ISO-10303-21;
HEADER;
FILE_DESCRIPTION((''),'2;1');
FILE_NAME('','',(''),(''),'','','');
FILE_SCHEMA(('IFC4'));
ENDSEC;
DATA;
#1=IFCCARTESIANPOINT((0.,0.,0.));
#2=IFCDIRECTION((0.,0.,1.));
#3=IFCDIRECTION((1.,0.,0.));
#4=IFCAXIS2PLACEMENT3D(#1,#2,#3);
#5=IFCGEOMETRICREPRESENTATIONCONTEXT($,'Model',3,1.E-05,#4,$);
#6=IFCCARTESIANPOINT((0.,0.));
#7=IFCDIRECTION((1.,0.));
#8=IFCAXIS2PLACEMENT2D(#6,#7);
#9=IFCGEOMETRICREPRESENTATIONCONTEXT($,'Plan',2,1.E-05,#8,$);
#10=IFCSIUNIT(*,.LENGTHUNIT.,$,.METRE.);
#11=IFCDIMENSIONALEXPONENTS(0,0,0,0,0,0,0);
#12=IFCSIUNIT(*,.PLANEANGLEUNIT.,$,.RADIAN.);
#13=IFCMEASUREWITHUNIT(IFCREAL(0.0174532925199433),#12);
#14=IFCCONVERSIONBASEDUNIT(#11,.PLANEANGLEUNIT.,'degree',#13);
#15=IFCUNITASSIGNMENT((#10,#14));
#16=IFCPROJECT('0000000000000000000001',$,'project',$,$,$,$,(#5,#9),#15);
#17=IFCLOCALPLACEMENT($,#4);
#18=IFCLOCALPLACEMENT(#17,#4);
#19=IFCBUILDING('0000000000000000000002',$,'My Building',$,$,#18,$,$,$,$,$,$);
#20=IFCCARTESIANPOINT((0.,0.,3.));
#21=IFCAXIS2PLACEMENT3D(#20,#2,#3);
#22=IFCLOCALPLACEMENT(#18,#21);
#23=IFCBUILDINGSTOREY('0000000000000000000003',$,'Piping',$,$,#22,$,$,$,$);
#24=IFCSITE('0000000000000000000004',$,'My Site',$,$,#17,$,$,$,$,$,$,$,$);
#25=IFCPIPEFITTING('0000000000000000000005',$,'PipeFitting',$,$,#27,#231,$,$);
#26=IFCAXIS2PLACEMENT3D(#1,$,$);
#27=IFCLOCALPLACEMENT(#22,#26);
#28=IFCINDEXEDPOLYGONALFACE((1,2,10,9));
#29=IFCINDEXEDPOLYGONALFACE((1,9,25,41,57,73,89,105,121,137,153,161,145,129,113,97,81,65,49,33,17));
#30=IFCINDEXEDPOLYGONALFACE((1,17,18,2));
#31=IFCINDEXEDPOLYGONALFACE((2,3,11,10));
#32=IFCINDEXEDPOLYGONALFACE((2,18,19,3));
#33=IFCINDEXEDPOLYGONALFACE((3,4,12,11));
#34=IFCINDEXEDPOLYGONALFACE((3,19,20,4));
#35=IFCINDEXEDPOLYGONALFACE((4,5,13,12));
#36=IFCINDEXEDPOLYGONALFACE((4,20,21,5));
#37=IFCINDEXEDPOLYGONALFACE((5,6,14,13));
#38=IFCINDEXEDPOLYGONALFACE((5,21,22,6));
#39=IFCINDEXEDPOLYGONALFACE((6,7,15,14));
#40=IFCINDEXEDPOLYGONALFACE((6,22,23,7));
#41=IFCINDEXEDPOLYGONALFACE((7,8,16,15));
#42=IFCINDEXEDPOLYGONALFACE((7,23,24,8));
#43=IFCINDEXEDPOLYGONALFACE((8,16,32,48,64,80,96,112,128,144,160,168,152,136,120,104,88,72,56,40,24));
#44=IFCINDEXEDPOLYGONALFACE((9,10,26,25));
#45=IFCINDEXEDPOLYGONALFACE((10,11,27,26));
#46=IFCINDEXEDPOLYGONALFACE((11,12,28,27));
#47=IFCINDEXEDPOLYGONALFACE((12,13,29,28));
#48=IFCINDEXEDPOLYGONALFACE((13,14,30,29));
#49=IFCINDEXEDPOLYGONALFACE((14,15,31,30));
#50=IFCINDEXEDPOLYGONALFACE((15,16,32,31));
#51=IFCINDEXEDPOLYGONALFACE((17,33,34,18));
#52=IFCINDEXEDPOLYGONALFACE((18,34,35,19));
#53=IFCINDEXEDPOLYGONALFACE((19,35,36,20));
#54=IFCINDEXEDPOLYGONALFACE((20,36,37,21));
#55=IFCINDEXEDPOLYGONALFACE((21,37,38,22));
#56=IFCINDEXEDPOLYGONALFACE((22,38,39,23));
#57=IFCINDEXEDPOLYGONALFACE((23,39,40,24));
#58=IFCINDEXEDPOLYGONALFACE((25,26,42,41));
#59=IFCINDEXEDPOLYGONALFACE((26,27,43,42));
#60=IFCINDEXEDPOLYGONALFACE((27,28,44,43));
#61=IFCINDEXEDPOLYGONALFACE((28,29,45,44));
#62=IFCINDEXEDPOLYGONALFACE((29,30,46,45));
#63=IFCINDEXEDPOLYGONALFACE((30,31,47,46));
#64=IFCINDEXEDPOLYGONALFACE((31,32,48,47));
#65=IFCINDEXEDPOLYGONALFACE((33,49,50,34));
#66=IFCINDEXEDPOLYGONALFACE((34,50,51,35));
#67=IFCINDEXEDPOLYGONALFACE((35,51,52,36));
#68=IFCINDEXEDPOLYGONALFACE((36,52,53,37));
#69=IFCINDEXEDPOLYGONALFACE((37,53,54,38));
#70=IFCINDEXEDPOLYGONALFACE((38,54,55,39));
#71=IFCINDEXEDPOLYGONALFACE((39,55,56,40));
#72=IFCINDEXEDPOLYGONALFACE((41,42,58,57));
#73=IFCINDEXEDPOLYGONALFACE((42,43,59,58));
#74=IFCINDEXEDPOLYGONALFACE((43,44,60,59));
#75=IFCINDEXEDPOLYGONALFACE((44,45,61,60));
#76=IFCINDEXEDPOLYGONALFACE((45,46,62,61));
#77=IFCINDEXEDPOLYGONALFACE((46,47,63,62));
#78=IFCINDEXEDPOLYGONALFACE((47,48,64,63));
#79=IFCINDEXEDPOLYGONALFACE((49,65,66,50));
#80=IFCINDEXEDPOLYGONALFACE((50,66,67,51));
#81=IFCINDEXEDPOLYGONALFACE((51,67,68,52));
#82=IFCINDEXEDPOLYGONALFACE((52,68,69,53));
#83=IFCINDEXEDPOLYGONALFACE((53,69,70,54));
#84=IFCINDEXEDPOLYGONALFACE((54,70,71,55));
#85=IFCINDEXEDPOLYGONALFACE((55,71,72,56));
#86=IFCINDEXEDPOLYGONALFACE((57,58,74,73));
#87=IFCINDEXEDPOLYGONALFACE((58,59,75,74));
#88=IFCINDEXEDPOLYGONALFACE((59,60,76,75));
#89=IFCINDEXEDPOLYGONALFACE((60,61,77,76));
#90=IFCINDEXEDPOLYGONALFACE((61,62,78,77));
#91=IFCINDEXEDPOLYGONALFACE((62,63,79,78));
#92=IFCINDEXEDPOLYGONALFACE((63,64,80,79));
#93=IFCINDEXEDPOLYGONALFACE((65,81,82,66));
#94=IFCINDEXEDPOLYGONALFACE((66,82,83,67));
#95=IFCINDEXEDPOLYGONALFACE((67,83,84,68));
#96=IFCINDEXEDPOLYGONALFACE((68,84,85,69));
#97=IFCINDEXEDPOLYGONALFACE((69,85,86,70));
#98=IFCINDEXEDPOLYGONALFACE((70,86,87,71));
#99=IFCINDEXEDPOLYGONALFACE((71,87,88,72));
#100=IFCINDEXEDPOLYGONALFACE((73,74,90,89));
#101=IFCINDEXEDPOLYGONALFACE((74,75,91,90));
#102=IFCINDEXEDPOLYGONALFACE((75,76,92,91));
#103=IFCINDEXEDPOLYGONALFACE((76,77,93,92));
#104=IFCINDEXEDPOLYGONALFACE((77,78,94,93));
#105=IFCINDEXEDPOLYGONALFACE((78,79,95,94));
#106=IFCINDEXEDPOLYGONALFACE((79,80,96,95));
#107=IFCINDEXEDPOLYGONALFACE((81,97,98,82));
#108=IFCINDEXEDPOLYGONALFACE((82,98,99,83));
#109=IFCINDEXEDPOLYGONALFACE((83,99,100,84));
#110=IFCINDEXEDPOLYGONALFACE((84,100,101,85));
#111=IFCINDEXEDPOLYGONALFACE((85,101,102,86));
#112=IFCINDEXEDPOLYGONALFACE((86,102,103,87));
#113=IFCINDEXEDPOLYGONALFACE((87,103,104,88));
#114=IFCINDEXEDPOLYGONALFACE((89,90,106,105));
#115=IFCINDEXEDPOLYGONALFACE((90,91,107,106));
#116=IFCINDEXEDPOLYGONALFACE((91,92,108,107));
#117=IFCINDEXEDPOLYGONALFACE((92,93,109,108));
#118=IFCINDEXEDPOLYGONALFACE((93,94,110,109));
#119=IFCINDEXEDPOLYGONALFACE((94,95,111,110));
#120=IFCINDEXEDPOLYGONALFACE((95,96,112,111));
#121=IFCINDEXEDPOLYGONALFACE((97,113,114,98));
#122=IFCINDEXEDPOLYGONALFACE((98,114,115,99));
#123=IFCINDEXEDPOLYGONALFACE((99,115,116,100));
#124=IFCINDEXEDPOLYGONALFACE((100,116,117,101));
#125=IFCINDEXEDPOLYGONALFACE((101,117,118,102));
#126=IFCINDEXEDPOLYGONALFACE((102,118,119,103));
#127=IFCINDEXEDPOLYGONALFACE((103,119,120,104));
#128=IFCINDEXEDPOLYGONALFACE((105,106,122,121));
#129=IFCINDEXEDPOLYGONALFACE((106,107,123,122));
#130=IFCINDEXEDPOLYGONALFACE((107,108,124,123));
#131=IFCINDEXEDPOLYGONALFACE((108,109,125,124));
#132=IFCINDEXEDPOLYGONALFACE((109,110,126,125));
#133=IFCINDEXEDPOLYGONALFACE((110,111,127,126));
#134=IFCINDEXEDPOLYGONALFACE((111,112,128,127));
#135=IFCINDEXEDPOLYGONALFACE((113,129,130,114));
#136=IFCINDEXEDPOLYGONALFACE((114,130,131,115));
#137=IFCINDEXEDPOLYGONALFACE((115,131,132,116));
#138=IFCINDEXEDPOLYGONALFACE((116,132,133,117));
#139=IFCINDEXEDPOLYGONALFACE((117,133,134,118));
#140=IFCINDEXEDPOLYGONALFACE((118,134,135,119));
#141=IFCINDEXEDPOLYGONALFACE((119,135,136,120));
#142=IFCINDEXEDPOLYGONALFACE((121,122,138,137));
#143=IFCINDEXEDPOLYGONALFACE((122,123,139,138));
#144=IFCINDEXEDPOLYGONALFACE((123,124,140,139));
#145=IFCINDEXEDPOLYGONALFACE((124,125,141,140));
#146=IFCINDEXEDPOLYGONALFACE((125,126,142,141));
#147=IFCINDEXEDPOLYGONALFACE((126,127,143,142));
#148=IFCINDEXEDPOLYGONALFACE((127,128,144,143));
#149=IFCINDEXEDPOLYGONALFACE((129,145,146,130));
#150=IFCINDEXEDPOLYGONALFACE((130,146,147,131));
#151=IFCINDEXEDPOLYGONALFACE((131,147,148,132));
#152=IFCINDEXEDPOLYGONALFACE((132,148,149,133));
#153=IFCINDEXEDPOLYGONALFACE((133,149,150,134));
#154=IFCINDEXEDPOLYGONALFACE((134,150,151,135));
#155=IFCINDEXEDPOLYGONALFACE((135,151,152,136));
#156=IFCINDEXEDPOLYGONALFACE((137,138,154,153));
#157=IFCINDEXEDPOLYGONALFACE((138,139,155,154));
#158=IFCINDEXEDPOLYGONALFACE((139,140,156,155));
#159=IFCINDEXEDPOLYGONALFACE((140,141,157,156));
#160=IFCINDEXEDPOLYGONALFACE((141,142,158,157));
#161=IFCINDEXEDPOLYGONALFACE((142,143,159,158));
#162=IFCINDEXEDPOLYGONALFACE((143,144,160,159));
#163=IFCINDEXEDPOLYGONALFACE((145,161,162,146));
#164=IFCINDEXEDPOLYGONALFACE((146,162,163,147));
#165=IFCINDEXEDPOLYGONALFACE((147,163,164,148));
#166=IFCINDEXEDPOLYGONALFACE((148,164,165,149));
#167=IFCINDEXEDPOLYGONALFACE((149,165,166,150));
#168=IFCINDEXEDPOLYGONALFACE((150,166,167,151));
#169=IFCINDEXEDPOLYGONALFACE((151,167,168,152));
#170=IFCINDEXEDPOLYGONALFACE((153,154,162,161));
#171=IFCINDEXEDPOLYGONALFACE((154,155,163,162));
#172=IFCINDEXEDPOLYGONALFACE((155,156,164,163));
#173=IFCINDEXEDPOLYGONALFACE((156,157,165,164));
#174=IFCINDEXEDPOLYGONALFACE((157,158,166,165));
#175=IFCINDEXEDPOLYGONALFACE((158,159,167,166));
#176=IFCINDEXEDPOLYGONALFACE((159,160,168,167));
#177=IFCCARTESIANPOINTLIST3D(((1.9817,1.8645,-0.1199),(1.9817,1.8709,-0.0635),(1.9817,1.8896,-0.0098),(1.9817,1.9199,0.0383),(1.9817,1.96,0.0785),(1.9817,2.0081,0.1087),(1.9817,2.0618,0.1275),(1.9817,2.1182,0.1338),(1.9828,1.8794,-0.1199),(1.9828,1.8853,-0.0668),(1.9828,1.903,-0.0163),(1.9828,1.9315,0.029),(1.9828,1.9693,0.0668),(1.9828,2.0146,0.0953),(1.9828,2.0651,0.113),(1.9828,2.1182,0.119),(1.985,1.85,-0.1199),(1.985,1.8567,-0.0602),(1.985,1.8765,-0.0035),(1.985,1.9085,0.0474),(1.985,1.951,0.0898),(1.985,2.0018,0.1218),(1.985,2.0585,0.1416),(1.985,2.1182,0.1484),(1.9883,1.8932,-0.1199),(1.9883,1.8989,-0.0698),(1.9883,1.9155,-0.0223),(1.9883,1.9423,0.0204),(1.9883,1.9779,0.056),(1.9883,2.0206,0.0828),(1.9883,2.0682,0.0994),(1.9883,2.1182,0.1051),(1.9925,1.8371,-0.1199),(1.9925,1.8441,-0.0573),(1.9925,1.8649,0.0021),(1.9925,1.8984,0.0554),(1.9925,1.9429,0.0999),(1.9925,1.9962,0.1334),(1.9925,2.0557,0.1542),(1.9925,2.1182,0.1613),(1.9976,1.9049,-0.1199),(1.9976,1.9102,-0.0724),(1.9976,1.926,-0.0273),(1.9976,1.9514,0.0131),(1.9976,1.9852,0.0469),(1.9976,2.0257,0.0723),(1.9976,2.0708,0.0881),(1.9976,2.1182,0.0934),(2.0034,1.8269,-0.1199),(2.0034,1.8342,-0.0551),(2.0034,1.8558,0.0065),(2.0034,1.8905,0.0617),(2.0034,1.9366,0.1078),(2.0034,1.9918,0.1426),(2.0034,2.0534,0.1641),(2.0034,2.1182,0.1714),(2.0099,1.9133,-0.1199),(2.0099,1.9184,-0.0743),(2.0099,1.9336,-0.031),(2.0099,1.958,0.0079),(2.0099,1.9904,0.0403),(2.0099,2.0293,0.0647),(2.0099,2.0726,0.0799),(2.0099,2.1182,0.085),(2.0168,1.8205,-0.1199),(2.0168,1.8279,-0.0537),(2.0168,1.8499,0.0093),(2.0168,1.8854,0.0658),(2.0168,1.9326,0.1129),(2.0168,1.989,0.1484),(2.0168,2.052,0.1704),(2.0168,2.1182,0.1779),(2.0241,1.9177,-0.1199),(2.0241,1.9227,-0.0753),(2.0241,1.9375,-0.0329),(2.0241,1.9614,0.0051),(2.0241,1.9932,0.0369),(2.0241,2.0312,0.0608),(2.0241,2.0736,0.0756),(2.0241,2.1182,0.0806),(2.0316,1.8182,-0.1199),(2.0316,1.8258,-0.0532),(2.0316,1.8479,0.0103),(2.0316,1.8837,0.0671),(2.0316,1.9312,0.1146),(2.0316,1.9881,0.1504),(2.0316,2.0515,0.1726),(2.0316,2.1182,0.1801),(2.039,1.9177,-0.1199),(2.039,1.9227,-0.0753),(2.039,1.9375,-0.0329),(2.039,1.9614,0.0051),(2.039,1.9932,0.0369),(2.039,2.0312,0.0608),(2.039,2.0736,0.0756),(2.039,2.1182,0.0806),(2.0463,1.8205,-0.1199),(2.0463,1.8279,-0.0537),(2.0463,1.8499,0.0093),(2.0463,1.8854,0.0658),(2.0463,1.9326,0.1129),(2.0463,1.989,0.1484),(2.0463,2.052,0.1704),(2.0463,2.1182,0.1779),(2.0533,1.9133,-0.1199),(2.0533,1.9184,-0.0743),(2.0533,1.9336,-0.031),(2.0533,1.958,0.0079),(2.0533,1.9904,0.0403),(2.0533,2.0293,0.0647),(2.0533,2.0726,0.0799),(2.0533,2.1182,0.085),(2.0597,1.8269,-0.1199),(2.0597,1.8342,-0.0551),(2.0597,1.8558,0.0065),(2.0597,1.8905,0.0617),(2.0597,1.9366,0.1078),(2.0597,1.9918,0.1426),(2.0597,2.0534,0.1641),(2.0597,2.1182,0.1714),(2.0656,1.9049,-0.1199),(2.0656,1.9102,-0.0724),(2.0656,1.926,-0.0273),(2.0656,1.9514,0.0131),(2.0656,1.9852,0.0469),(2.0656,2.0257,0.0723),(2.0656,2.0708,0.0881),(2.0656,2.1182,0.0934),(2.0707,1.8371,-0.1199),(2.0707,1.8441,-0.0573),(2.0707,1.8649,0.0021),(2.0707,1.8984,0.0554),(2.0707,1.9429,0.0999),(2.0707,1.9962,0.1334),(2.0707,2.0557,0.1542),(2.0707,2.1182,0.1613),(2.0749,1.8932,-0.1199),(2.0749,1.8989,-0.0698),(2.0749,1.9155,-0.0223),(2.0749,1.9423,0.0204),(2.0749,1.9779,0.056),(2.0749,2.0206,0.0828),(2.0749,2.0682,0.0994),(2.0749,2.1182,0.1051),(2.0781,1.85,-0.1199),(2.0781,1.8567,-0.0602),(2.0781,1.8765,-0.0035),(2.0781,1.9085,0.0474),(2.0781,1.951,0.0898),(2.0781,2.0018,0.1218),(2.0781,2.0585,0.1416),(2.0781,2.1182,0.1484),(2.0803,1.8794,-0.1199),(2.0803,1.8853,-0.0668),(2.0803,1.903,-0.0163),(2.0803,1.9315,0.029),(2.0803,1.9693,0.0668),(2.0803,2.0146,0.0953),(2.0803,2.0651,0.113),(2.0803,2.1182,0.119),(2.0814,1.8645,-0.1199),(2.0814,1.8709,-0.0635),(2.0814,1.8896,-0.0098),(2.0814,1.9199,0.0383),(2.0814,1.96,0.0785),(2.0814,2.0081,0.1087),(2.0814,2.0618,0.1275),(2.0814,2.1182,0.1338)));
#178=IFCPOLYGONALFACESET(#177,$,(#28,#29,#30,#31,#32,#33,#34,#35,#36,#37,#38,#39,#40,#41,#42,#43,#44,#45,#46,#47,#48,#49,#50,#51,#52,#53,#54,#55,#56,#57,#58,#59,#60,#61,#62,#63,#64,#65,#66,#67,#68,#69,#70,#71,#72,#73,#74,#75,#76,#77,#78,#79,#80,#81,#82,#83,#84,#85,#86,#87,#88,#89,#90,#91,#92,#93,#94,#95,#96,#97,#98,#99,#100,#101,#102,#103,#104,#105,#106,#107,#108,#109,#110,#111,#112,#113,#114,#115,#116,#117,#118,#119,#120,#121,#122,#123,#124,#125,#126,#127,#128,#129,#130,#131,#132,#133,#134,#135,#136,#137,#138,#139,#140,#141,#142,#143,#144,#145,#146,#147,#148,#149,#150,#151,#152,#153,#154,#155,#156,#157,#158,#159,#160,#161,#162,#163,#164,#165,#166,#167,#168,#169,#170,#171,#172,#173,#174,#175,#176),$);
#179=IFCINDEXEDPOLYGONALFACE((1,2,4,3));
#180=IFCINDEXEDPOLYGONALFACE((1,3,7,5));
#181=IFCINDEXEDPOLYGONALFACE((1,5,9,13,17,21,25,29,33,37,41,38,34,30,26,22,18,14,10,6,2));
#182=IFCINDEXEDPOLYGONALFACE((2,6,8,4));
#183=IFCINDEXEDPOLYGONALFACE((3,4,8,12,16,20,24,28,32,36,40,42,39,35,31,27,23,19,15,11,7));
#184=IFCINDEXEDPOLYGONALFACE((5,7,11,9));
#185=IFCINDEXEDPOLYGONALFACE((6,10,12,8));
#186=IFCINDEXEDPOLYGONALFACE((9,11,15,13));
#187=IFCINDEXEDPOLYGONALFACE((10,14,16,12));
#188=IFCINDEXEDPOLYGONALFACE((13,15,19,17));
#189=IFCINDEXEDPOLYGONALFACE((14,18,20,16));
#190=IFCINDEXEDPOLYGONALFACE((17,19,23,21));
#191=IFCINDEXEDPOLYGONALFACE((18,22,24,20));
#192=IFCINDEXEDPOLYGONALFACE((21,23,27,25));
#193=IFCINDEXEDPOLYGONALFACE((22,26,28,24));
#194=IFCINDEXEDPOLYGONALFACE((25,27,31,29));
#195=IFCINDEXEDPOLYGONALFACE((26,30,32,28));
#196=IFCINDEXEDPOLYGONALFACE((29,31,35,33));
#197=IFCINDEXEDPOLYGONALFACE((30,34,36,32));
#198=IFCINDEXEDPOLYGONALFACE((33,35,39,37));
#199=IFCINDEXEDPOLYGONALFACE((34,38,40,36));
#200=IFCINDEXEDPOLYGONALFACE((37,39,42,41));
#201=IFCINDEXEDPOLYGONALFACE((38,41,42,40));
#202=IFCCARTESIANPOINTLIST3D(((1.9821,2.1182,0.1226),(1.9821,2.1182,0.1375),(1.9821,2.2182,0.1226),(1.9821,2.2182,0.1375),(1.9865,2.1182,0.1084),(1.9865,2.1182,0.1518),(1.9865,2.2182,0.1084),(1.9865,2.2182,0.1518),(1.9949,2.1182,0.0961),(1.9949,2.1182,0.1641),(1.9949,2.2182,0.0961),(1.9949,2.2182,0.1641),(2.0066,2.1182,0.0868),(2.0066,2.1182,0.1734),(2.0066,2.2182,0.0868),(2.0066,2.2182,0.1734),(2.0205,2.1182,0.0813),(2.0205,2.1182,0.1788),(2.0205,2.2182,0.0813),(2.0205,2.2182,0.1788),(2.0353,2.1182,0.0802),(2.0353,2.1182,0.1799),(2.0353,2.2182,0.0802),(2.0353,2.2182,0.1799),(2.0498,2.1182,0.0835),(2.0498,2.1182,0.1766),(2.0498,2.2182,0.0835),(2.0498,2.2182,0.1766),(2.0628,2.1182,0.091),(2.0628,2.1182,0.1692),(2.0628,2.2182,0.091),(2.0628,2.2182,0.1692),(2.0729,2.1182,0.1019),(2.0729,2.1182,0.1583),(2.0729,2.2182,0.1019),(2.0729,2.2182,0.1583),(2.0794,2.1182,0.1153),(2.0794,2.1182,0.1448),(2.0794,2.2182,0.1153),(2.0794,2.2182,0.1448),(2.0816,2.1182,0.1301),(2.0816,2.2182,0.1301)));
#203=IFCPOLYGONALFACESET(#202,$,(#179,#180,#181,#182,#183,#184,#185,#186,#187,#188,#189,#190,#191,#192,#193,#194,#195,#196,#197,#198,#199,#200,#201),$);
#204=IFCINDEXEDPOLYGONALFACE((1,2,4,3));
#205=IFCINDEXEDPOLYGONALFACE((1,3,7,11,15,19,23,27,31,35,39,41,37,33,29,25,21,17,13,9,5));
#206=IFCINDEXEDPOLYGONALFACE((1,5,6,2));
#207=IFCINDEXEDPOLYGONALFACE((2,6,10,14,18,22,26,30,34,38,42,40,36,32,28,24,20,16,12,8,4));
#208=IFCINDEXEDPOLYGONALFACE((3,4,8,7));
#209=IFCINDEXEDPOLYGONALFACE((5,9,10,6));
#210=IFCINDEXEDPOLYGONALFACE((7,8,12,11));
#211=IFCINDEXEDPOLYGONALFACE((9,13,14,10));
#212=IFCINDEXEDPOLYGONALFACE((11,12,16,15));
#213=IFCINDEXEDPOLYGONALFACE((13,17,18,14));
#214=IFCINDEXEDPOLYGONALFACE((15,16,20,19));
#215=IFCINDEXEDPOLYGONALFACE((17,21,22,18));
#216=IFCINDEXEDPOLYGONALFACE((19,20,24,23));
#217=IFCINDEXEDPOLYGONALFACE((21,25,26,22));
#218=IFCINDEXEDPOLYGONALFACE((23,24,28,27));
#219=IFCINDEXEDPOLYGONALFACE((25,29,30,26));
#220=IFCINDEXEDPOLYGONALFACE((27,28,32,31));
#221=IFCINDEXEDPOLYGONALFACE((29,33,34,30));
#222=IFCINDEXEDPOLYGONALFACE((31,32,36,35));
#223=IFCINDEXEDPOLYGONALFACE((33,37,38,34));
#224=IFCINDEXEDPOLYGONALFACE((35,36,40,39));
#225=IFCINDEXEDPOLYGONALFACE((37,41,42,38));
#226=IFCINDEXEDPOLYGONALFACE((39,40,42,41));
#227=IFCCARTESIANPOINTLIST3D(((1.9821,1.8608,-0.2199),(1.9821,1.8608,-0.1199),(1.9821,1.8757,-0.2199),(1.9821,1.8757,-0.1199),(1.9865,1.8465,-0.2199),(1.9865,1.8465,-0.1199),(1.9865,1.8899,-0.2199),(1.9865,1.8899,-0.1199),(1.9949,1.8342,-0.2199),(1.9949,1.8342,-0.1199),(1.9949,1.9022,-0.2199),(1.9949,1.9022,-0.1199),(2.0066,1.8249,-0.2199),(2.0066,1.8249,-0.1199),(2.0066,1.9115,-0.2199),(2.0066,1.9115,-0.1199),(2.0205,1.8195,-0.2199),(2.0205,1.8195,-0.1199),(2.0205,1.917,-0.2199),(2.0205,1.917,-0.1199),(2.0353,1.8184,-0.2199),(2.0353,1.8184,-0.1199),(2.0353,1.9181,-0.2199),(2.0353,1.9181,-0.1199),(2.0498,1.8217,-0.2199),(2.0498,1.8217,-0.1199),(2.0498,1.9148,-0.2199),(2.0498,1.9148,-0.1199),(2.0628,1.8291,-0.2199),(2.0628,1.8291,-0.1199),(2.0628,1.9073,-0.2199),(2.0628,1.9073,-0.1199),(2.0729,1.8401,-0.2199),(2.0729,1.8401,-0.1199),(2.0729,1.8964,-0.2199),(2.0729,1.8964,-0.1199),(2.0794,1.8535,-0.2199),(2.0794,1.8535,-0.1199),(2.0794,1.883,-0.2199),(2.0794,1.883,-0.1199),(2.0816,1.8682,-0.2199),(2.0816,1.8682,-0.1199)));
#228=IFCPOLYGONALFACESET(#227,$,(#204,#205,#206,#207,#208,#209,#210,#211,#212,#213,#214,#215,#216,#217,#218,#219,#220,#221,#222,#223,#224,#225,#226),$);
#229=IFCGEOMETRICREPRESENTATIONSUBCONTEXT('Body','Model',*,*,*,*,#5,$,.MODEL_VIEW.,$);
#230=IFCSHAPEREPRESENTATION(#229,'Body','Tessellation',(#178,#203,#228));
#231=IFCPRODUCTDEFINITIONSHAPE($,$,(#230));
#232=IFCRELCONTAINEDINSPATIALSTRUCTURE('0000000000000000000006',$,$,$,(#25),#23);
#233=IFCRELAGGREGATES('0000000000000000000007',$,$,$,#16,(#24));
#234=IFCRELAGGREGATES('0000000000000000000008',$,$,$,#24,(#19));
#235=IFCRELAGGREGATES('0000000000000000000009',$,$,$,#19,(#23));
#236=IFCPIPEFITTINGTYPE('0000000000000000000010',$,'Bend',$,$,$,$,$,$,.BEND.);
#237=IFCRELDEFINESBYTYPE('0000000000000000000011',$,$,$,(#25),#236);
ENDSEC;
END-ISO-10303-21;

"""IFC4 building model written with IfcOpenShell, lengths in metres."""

from ifc_helpers import new_model, entity, si_unit, converted_unit, frame, origin_with_axes, origin_2d_with_axis, place, context, subcontext, project, spatial, circle, extrude, source, transform, mapped, type_object, type_shapes, element, save


model = new_model("IFC4")

# Units and contexts
model_context = context("Model", 3, precision=1e-05, world=origin_with_axes())
plan_context = context("Plan", 2, precision=1e-05, world=origin_2d_with_axis())
body_context = subcontext(model_context, "Body", "Model", "MODEL_VIEW")
ifc_project = project(units=[si_unit("LENGTHUNIT", "METRE"), converted_unit("PLANEANGLEUNIT", "degree", entity("IfcReal", 0.0174532925199433), si_unit("PLANEANGLEUNIT", "RADIAN"), dimensions=[0, 0, 0, 0, 0, 0, 0])], contexts=[model_context, plan_context])

# Site, building, storey
site_placement = place(None, origin_with_axes())
site = spatial("IfcSite", under=ifc_project, at=site_placement, Name="My Site")
building_placement = place(site_placement, origin_with_axes())
building = spatial("IfcBuilding", under=site, at=building_placement, Name="My Building")
storey_placement = place(building_placement, frame((0.0, 0.0, 3.0), z_axis=(0.0, 0.0, 1.0), x_axis=(1.0, 0.0, 0.0)))
storey = spatial("IfcBuildingStorey", under=building, at=storey_placement, Name="Piping")

# Pipe fitting
pipe_fitting_type_1 = type_object("IfcPipeFittingType", Name="Bend", PredefinedType="BEND")
shared_shape_1 = source(origin_with_axes(), body_context, "Body", "SolidModel", [
    entity("IfcSweptDiskSolid", entity("IfcIndexedPolyCurve", entity("IfcCartesianPointList3D", [[0.0, 0.0, 0.1], [0.0, -0.0732, 0.2768], [0.0, -0.25, 0.35]]), [entity("IfcArcIndex", [1, 2, 3])]), 0.05),
    extrude(circle(Radius=0.05), origin_with_axes(), (0.0, 0.0, 1.0), 0.1),
    extrude(circle(Radius=0.05), frame((0.0, -0.25, 0.35), z_axis=(0.0, -1.0, -0.000015), x_axis=(1.0, 0.0, 0.0)), (0.0, 0.0, 1.0), 0.1),
])
type_shapes(pipe_fitting_type_1, [shared_shape_1])
for number, where, z_axis, x_axis, name in (
    (1, (2.0316, 2.2182, 0.1301), (0.0, -1.0, 0.000015), (1.0, 0.0, 0.0), "PipeFitting"),
):
    element("IfcPipeFitting", number, at=place(storey_placement, frame(where, z_axis=z_axis, x_axis=x_axis)), inside=storey, type_object=pipe_fitting_type_1, Name=name, context=body_context, shape_type="MappedRepresentation", body=[
        mapped(shared_shape_1, transform((0.0, 0.0, 0.0), x_axis=(1.0, 0.0, 0.0), y_axis=(0.0, 1.0, 0.0), z_axis=(0.0, 0.0, 1.0), scale=1.0)),
    ])

save(model, "model.ifc")
